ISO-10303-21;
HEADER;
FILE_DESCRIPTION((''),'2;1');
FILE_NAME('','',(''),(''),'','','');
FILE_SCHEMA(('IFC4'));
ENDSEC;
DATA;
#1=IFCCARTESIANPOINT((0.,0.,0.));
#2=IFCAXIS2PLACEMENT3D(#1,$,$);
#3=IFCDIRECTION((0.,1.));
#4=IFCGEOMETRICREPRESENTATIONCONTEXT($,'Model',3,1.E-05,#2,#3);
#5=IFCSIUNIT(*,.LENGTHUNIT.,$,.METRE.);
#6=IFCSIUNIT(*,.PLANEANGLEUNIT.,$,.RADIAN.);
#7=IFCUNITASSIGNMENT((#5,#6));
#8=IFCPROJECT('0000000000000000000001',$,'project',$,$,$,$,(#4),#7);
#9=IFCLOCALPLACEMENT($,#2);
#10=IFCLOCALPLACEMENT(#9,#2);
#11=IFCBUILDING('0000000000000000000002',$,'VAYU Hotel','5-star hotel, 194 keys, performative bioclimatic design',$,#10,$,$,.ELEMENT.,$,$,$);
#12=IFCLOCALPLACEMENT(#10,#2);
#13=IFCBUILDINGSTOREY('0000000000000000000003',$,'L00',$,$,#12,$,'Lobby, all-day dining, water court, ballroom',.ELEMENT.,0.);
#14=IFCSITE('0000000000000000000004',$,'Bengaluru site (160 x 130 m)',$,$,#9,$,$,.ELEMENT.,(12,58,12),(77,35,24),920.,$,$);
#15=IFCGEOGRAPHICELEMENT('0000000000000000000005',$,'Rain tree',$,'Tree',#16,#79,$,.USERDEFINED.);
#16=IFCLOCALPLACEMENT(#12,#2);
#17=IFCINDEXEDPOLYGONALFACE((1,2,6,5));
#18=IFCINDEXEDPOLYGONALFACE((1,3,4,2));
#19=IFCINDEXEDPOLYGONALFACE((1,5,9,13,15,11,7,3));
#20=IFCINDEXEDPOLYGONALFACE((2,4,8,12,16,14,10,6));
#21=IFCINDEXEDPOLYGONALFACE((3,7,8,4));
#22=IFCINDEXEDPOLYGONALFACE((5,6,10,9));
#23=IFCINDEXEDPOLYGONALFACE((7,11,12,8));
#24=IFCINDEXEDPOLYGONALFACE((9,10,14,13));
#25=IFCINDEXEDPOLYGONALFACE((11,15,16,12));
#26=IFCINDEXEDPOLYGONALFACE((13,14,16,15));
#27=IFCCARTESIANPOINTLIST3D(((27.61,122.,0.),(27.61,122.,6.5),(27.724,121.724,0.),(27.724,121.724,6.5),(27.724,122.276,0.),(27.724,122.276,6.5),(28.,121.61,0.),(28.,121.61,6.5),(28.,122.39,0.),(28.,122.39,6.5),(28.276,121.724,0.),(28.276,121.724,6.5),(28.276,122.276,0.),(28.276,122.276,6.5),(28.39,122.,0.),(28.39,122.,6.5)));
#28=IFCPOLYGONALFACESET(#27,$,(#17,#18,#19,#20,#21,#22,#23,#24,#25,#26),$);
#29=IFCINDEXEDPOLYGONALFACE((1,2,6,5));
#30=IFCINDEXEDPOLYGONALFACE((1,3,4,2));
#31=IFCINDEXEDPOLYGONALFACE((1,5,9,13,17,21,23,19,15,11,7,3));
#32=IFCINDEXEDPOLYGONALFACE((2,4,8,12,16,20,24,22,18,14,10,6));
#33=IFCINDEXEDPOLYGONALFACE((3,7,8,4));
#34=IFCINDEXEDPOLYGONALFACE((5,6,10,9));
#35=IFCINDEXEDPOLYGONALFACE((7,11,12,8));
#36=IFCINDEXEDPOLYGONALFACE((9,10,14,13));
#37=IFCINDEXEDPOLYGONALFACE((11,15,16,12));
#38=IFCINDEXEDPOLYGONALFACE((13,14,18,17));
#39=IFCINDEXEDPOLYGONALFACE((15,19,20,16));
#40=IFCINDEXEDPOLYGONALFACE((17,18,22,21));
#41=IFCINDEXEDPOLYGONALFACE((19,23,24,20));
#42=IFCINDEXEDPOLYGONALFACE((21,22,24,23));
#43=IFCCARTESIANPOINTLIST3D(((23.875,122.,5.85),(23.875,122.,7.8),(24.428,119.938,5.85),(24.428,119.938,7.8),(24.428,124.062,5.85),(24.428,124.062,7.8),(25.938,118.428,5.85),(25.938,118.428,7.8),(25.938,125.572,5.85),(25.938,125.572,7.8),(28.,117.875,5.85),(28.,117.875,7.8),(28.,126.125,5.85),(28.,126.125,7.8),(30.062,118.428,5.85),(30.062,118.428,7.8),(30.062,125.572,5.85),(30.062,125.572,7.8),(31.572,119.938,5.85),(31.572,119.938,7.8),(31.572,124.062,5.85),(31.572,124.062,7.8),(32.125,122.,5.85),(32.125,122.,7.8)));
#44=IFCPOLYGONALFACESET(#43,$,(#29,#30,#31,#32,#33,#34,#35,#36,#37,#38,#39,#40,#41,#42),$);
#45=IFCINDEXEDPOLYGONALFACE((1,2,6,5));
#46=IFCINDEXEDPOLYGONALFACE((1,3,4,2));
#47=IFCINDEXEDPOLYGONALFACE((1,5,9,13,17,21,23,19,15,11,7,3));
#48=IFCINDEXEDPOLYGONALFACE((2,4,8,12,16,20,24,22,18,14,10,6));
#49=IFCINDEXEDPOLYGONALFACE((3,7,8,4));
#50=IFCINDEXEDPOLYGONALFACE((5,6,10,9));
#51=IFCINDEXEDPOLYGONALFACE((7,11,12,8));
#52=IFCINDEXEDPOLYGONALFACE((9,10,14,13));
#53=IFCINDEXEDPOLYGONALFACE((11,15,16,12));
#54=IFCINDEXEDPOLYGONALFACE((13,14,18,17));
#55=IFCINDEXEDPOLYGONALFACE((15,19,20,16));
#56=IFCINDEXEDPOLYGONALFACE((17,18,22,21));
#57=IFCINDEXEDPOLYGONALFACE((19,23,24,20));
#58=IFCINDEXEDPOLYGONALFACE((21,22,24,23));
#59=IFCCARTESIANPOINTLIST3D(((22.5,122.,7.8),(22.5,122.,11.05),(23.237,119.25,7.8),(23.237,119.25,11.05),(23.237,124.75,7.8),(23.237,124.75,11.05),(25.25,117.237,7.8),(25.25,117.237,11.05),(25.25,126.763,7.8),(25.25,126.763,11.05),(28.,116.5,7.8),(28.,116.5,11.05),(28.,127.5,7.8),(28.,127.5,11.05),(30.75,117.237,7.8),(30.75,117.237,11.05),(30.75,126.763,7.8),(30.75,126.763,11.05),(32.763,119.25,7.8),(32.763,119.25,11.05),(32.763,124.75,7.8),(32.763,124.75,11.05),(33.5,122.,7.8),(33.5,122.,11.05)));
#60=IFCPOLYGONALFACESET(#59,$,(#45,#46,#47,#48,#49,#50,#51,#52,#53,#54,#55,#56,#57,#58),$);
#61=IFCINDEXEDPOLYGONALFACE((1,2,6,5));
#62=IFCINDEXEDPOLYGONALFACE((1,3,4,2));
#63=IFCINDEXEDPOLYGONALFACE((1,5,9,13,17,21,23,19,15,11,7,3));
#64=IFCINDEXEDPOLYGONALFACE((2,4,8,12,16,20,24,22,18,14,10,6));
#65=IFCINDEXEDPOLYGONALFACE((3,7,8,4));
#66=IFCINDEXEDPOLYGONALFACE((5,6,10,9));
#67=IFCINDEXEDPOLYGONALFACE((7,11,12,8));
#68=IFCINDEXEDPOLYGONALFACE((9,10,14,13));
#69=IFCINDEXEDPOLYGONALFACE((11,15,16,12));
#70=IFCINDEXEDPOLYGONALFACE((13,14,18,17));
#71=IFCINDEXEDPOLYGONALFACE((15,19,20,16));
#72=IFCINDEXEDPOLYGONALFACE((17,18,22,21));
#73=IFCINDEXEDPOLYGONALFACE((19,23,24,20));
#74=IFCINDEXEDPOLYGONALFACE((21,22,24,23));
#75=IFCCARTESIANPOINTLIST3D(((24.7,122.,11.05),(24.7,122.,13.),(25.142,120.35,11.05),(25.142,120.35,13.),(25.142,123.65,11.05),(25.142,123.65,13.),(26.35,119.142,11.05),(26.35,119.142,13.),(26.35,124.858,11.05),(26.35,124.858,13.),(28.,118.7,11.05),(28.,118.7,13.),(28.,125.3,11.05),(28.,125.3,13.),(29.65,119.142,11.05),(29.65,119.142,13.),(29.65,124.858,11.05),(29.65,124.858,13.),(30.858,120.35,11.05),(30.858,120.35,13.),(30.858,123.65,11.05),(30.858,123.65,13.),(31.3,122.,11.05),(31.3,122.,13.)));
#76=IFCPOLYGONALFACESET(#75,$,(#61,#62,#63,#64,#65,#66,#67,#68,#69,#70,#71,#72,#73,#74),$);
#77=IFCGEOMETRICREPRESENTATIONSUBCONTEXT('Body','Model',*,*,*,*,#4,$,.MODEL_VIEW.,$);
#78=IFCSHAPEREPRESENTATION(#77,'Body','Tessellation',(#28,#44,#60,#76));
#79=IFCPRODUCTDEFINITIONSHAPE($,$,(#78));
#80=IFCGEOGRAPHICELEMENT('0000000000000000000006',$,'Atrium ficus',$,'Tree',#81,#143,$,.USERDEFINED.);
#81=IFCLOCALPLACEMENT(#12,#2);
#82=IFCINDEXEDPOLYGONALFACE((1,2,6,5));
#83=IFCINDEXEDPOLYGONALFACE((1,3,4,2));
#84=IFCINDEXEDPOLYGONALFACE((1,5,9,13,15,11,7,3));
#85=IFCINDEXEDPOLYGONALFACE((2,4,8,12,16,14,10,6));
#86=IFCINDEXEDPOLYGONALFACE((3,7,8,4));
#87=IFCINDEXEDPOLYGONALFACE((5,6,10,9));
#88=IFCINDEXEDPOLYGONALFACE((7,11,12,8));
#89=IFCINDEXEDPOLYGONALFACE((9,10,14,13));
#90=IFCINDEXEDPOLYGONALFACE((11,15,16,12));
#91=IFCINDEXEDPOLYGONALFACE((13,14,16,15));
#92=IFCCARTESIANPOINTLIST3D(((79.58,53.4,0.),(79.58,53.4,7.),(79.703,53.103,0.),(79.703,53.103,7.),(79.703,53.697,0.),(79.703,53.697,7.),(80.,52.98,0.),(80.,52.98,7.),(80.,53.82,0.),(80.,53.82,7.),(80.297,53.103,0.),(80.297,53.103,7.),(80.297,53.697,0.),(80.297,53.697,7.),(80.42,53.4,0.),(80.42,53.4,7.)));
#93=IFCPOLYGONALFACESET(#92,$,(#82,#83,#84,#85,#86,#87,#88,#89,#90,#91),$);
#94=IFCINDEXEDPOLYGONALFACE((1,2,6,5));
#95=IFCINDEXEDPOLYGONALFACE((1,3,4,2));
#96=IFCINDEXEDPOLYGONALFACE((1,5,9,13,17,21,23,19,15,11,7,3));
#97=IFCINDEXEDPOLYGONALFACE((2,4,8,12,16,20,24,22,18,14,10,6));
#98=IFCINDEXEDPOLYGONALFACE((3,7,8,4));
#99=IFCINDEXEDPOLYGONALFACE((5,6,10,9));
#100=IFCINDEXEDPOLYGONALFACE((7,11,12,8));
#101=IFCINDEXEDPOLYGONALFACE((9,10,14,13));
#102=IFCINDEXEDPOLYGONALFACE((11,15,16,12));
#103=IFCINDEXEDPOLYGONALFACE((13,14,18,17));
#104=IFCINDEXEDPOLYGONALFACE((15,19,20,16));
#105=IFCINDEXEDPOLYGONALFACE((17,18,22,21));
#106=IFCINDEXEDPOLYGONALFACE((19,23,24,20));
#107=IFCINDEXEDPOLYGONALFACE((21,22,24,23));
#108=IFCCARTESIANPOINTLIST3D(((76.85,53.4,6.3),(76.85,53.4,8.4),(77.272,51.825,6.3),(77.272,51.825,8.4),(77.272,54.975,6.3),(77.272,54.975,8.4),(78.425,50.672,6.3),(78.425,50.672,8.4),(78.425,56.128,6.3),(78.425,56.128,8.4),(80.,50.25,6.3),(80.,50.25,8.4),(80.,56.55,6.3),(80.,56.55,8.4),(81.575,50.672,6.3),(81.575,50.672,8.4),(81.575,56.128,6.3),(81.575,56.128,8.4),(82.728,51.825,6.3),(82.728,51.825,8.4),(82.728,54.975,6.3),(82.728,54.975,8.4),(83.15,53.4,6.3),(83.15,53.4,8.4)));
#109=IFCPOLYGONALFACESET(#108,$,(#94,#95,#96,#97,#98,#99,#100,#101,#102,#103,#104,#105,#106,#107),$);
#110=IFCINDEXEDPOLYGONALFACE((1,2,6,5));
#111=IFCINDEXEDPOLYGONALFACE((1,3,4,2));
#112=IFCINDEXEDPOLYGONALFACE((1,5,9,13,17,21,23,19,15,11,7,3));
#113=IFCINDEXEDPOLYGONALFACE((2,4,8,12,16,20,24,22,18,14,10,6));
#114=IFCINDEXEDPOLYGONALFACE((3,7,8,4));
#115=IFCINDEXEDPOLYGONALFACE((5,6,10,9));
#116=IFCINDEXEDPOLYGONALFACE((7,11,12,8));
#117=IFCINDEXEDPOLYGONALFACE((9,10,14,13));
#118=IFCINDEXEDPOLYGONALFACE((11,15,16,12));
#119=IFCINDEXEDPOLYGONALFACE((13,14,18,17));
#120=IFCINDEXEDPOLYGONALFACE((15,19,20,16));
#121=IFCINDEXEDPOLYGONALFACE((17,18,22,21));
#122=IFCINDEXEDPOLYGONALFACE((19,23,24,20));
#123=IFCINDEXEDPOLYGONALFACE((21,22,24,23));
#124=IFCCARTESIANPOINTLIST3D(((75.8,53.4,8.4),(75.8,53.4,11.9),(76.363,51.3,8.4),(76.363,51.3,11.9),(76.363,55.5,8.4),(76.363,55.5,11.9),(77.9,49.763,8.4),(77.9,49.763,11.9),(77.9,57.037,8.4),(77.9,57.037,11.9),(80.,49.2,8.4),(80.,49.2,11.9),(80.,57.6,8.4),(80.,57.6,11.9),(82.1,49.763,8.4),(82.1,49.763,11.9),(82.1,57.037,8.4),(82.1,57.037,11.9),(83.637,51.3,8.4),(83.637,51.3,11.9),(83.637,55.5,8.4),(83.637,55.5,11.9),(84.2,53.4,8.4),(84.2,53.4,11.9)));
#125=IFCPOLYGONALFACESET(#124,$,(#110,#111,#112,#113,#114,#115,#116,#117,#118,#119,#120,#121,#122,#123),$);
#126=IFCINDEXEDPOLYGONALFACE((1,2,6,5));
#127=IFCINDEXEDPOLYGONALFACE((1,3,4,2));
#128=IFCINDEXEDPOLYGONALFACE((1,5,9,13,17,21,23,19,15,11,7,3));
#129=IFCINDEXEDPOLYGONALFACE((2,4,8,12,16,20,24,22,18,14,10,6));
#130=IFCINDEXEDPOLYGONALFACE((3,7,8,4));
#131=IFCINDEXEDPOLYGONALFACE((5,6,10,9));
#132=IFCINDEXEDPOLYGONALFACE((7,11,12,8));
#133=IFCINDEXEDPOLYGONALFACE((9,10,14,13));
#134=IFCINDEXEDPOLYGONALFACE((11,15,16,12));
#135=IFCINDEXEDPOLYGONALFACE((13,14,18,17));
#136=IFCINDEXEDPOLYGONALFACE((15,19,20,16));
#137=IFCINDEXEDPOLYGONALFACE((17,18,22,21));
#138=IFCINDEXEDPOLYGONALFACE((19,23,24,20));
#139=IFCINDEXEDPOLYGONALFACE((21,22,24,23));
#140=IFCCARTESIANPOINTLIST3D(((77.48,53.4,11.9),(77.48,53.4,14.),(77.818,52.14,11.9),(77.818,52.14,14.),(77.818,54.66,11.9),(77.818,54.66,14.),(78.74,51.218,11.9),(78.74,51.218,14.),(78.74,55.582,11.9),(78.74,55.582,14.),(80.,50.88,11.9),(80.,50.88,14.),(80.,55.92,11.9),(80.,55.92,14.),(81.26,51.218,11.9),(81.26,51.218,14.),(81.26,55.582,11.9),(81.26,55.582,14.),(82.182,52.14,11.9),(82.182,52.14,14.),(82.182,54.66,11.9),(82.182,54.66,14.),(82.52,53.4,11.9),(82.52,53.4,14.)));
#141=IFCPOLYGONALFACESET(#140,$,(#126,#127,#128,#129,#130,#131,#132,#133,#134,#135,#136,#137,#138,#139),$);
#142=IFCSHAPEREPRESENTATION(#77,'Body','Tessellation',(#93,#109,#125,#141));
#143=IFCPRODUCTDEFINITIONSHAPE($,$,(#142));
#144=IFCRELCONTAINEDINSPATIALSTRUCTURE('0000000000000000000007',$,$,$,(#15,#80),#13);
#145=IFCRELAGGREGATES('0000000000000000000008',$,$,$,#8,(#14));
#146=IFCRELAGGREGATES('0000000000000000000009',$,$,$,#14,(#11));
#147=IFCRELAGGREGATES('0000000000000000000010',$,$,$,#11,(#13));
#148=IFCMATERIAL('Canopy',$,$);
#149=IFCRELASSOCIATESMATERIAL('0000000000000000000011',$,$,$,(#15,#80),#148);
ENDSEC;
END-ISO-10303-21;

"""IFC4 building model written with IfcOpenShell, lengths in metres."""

from ifc_helpers import new_model, si_unit, direction, frame, origin, place, context, subcontext, project, spatial, polyline, outline, extrude, material, element, save


model = new_model("IFC4")

# Units and contexts
model_context = context("Model", 3, precision=1e-05, world=origin(), true_north=direction((0.0, 1.0)))
body_context = subcontext(model_context, "Body", "Model", "MODEL_VIEW")
ifc_project = project(units=[si_unit("LENGTHUNIT", "METRE"), si_unit("PLANEANGLEUNIT", "RADIAN")], contexts=[model_context])

# Site, building, storey
site_placement = place(None, origin())
site = spatial("IfcSite", under=ifc_project, at=site_placement, Name="Bengaluru site (160 x 130 m)", CompositionType="ELEMENT", RefLatitude=(12, 58, 12), RefLongitude=(77, 35, 24), RefElevation=920.0)
building_placement = place(site_placement, origin())
building = spatial("IfcBuilding", under=site, at=building_placement, Name="VAYU Hotel", Description="5-star hotel, 194 keys, performative bioclimatic design", CompositionType="ELEMENT")
storey_placement = place(building_placement, origin())
storey = spatial("IfcBuildingStorey", under=building, at=storey_placement, Name="L00", LongName="Lobby, all-day dining, water court, ballroom", CompositionType="ELEMENT", Elevation=0.0)

# Geographic elements
ifc_material_1 = material(Name="Canopy")
geographic_element_1_placement = place(storey_placement, origin())
element("IfcGeographicElement", 1, at=geographic_element_1_placement, inside=storey, material=ifc_material_1, Name="Rain tree", ObjectType="Tree", PredefinedType="USERDEFINED", context=body_context, shape_type="SweptSolid", body=[
    extrude(outline(polyline([(28.39, 122.0), (28.276, 122.276), (28.0, 122.39), (27.724, 122.276), (27.61, 122.0), (27.724, 121.724), (28.0, 121.61), (28.276, 121.724), (28.39, 122.0)])), origin(), (0.0, 0.0, 1.0), 6.5),
    extrude(outline(polyline([(32.125, 122.0), (31.572, 124.062), (30.062, 125.572), (28.0, 126.125), (25.938, 125.572), (24.428, 124.062), (23.875, 122.0), (24.428, 119.938), (25.938, 118.428), (28.0, 117.875), (30.062, 118.428), (31.572, 119.938), (32.125, 122.0)])), frame((0.0, 0.0, 5.85)), (0.0, 0.0, 1.0), 1.95),
    extrude(outline(polyline([(33.5, 122.0), (32.763, 124.75), (30.75, 126.763), (28.0, 127.5), (25.25, 126.763), (23.237, 124.75), (22.5, 122.0), (23.237, 119.25), (25.25, 117.237), (28.0, 116.5), (30.75, 117.237), (32.763, 119.25), (33.5, 122.0)])), frame((0.0, 0.0, 7.8)), (0.0, 0.0, 1.0), 3.25),
    extrude(outline(polyline([(31.3, 122.0), (30.858, 123.65), (29.65, 124.858), (28.0, 125.3), (26.35, 124.858), (25.142, 123.65), (24.7, 122.0), (25.142, 120.35), (26.35, 119.142), (28.0, 118.7), (29.65, 119.142), (30.858, 120.35), (31.3, 122.0)])), frame((0.0, 0.0, 11.05)), (0.0, 0.0, 1.0), 1.95),
])
geographic_element_2_placement = place(storey_placement, origin())
element("IfcGeographicElement", 2, at=geographic_element_2_placement, inside=storey, material=ifc_material_1, Name="Atrium ficus", ObjectType="Tree", PredefinedType="USERDEFINED", context=body_context, shape_type="SweptSolid", body=[
    extrude(outline(polyline([(80.42, 53.4), (80.297, 53.697), (80.0, 53.82), (79.703, 53.697), (79.58, 53.4), (79.703, 53.103), (80.0, 52.98), (80.297, 53.103), (80.42, 53.4)])), origin(), (0.0, 0.0, 1.0), 7.0),
    extrude(outline(polyline([(83.15, 53.4), (82.728, 54.975), (81.575, 56.128), (80.0, 56.55), (78.425, 56.128), (77.272, 54.975), (76.85, 53.4), (77.272, 51.825), (78.425, 50.672), (80.0, 50.25), (81.575, 50.672), (82.728, 51.825), (83.15, 53.4)])), frame((0.0, 0.0, 6.3)), (0.0, 0.0, 1.0), 2.1),
    extrude(outline(polyline([(84.2, 53.4), (83.637, 55.5), (82.1, 57.037), (80.0, 57.6), (77.9, 57.037), (76.363, 55.5), (75.8, 53.4), (76.363, 51.3), (77.9, 49.763), (80.0, 49.2), (82.1, 49.763), (83.637, 51.3), (84.2, 53.4)])), frame((0.0, 0.0, 8.4)), (0.0, 0.0, 1.0), 3.5),
    extrude(outline(polyline([(82.52, 53.4), (82.182, 54.66), (81.26, 55.582), (80.0, 55.92), (78.74, 55.582), (77.818, 54.66), (77.48, 53.4), (77.818, 52.14), (78.74, 51.218), (80.0, 50.88), (81.26, 51.218), (82.182, 52.14), (82.52, 53.4)])), frame((0.0, 0.0, 11.9)), (0.0, 0.0, 1.0), 2.1),
])

save(model, "model.ifc")
